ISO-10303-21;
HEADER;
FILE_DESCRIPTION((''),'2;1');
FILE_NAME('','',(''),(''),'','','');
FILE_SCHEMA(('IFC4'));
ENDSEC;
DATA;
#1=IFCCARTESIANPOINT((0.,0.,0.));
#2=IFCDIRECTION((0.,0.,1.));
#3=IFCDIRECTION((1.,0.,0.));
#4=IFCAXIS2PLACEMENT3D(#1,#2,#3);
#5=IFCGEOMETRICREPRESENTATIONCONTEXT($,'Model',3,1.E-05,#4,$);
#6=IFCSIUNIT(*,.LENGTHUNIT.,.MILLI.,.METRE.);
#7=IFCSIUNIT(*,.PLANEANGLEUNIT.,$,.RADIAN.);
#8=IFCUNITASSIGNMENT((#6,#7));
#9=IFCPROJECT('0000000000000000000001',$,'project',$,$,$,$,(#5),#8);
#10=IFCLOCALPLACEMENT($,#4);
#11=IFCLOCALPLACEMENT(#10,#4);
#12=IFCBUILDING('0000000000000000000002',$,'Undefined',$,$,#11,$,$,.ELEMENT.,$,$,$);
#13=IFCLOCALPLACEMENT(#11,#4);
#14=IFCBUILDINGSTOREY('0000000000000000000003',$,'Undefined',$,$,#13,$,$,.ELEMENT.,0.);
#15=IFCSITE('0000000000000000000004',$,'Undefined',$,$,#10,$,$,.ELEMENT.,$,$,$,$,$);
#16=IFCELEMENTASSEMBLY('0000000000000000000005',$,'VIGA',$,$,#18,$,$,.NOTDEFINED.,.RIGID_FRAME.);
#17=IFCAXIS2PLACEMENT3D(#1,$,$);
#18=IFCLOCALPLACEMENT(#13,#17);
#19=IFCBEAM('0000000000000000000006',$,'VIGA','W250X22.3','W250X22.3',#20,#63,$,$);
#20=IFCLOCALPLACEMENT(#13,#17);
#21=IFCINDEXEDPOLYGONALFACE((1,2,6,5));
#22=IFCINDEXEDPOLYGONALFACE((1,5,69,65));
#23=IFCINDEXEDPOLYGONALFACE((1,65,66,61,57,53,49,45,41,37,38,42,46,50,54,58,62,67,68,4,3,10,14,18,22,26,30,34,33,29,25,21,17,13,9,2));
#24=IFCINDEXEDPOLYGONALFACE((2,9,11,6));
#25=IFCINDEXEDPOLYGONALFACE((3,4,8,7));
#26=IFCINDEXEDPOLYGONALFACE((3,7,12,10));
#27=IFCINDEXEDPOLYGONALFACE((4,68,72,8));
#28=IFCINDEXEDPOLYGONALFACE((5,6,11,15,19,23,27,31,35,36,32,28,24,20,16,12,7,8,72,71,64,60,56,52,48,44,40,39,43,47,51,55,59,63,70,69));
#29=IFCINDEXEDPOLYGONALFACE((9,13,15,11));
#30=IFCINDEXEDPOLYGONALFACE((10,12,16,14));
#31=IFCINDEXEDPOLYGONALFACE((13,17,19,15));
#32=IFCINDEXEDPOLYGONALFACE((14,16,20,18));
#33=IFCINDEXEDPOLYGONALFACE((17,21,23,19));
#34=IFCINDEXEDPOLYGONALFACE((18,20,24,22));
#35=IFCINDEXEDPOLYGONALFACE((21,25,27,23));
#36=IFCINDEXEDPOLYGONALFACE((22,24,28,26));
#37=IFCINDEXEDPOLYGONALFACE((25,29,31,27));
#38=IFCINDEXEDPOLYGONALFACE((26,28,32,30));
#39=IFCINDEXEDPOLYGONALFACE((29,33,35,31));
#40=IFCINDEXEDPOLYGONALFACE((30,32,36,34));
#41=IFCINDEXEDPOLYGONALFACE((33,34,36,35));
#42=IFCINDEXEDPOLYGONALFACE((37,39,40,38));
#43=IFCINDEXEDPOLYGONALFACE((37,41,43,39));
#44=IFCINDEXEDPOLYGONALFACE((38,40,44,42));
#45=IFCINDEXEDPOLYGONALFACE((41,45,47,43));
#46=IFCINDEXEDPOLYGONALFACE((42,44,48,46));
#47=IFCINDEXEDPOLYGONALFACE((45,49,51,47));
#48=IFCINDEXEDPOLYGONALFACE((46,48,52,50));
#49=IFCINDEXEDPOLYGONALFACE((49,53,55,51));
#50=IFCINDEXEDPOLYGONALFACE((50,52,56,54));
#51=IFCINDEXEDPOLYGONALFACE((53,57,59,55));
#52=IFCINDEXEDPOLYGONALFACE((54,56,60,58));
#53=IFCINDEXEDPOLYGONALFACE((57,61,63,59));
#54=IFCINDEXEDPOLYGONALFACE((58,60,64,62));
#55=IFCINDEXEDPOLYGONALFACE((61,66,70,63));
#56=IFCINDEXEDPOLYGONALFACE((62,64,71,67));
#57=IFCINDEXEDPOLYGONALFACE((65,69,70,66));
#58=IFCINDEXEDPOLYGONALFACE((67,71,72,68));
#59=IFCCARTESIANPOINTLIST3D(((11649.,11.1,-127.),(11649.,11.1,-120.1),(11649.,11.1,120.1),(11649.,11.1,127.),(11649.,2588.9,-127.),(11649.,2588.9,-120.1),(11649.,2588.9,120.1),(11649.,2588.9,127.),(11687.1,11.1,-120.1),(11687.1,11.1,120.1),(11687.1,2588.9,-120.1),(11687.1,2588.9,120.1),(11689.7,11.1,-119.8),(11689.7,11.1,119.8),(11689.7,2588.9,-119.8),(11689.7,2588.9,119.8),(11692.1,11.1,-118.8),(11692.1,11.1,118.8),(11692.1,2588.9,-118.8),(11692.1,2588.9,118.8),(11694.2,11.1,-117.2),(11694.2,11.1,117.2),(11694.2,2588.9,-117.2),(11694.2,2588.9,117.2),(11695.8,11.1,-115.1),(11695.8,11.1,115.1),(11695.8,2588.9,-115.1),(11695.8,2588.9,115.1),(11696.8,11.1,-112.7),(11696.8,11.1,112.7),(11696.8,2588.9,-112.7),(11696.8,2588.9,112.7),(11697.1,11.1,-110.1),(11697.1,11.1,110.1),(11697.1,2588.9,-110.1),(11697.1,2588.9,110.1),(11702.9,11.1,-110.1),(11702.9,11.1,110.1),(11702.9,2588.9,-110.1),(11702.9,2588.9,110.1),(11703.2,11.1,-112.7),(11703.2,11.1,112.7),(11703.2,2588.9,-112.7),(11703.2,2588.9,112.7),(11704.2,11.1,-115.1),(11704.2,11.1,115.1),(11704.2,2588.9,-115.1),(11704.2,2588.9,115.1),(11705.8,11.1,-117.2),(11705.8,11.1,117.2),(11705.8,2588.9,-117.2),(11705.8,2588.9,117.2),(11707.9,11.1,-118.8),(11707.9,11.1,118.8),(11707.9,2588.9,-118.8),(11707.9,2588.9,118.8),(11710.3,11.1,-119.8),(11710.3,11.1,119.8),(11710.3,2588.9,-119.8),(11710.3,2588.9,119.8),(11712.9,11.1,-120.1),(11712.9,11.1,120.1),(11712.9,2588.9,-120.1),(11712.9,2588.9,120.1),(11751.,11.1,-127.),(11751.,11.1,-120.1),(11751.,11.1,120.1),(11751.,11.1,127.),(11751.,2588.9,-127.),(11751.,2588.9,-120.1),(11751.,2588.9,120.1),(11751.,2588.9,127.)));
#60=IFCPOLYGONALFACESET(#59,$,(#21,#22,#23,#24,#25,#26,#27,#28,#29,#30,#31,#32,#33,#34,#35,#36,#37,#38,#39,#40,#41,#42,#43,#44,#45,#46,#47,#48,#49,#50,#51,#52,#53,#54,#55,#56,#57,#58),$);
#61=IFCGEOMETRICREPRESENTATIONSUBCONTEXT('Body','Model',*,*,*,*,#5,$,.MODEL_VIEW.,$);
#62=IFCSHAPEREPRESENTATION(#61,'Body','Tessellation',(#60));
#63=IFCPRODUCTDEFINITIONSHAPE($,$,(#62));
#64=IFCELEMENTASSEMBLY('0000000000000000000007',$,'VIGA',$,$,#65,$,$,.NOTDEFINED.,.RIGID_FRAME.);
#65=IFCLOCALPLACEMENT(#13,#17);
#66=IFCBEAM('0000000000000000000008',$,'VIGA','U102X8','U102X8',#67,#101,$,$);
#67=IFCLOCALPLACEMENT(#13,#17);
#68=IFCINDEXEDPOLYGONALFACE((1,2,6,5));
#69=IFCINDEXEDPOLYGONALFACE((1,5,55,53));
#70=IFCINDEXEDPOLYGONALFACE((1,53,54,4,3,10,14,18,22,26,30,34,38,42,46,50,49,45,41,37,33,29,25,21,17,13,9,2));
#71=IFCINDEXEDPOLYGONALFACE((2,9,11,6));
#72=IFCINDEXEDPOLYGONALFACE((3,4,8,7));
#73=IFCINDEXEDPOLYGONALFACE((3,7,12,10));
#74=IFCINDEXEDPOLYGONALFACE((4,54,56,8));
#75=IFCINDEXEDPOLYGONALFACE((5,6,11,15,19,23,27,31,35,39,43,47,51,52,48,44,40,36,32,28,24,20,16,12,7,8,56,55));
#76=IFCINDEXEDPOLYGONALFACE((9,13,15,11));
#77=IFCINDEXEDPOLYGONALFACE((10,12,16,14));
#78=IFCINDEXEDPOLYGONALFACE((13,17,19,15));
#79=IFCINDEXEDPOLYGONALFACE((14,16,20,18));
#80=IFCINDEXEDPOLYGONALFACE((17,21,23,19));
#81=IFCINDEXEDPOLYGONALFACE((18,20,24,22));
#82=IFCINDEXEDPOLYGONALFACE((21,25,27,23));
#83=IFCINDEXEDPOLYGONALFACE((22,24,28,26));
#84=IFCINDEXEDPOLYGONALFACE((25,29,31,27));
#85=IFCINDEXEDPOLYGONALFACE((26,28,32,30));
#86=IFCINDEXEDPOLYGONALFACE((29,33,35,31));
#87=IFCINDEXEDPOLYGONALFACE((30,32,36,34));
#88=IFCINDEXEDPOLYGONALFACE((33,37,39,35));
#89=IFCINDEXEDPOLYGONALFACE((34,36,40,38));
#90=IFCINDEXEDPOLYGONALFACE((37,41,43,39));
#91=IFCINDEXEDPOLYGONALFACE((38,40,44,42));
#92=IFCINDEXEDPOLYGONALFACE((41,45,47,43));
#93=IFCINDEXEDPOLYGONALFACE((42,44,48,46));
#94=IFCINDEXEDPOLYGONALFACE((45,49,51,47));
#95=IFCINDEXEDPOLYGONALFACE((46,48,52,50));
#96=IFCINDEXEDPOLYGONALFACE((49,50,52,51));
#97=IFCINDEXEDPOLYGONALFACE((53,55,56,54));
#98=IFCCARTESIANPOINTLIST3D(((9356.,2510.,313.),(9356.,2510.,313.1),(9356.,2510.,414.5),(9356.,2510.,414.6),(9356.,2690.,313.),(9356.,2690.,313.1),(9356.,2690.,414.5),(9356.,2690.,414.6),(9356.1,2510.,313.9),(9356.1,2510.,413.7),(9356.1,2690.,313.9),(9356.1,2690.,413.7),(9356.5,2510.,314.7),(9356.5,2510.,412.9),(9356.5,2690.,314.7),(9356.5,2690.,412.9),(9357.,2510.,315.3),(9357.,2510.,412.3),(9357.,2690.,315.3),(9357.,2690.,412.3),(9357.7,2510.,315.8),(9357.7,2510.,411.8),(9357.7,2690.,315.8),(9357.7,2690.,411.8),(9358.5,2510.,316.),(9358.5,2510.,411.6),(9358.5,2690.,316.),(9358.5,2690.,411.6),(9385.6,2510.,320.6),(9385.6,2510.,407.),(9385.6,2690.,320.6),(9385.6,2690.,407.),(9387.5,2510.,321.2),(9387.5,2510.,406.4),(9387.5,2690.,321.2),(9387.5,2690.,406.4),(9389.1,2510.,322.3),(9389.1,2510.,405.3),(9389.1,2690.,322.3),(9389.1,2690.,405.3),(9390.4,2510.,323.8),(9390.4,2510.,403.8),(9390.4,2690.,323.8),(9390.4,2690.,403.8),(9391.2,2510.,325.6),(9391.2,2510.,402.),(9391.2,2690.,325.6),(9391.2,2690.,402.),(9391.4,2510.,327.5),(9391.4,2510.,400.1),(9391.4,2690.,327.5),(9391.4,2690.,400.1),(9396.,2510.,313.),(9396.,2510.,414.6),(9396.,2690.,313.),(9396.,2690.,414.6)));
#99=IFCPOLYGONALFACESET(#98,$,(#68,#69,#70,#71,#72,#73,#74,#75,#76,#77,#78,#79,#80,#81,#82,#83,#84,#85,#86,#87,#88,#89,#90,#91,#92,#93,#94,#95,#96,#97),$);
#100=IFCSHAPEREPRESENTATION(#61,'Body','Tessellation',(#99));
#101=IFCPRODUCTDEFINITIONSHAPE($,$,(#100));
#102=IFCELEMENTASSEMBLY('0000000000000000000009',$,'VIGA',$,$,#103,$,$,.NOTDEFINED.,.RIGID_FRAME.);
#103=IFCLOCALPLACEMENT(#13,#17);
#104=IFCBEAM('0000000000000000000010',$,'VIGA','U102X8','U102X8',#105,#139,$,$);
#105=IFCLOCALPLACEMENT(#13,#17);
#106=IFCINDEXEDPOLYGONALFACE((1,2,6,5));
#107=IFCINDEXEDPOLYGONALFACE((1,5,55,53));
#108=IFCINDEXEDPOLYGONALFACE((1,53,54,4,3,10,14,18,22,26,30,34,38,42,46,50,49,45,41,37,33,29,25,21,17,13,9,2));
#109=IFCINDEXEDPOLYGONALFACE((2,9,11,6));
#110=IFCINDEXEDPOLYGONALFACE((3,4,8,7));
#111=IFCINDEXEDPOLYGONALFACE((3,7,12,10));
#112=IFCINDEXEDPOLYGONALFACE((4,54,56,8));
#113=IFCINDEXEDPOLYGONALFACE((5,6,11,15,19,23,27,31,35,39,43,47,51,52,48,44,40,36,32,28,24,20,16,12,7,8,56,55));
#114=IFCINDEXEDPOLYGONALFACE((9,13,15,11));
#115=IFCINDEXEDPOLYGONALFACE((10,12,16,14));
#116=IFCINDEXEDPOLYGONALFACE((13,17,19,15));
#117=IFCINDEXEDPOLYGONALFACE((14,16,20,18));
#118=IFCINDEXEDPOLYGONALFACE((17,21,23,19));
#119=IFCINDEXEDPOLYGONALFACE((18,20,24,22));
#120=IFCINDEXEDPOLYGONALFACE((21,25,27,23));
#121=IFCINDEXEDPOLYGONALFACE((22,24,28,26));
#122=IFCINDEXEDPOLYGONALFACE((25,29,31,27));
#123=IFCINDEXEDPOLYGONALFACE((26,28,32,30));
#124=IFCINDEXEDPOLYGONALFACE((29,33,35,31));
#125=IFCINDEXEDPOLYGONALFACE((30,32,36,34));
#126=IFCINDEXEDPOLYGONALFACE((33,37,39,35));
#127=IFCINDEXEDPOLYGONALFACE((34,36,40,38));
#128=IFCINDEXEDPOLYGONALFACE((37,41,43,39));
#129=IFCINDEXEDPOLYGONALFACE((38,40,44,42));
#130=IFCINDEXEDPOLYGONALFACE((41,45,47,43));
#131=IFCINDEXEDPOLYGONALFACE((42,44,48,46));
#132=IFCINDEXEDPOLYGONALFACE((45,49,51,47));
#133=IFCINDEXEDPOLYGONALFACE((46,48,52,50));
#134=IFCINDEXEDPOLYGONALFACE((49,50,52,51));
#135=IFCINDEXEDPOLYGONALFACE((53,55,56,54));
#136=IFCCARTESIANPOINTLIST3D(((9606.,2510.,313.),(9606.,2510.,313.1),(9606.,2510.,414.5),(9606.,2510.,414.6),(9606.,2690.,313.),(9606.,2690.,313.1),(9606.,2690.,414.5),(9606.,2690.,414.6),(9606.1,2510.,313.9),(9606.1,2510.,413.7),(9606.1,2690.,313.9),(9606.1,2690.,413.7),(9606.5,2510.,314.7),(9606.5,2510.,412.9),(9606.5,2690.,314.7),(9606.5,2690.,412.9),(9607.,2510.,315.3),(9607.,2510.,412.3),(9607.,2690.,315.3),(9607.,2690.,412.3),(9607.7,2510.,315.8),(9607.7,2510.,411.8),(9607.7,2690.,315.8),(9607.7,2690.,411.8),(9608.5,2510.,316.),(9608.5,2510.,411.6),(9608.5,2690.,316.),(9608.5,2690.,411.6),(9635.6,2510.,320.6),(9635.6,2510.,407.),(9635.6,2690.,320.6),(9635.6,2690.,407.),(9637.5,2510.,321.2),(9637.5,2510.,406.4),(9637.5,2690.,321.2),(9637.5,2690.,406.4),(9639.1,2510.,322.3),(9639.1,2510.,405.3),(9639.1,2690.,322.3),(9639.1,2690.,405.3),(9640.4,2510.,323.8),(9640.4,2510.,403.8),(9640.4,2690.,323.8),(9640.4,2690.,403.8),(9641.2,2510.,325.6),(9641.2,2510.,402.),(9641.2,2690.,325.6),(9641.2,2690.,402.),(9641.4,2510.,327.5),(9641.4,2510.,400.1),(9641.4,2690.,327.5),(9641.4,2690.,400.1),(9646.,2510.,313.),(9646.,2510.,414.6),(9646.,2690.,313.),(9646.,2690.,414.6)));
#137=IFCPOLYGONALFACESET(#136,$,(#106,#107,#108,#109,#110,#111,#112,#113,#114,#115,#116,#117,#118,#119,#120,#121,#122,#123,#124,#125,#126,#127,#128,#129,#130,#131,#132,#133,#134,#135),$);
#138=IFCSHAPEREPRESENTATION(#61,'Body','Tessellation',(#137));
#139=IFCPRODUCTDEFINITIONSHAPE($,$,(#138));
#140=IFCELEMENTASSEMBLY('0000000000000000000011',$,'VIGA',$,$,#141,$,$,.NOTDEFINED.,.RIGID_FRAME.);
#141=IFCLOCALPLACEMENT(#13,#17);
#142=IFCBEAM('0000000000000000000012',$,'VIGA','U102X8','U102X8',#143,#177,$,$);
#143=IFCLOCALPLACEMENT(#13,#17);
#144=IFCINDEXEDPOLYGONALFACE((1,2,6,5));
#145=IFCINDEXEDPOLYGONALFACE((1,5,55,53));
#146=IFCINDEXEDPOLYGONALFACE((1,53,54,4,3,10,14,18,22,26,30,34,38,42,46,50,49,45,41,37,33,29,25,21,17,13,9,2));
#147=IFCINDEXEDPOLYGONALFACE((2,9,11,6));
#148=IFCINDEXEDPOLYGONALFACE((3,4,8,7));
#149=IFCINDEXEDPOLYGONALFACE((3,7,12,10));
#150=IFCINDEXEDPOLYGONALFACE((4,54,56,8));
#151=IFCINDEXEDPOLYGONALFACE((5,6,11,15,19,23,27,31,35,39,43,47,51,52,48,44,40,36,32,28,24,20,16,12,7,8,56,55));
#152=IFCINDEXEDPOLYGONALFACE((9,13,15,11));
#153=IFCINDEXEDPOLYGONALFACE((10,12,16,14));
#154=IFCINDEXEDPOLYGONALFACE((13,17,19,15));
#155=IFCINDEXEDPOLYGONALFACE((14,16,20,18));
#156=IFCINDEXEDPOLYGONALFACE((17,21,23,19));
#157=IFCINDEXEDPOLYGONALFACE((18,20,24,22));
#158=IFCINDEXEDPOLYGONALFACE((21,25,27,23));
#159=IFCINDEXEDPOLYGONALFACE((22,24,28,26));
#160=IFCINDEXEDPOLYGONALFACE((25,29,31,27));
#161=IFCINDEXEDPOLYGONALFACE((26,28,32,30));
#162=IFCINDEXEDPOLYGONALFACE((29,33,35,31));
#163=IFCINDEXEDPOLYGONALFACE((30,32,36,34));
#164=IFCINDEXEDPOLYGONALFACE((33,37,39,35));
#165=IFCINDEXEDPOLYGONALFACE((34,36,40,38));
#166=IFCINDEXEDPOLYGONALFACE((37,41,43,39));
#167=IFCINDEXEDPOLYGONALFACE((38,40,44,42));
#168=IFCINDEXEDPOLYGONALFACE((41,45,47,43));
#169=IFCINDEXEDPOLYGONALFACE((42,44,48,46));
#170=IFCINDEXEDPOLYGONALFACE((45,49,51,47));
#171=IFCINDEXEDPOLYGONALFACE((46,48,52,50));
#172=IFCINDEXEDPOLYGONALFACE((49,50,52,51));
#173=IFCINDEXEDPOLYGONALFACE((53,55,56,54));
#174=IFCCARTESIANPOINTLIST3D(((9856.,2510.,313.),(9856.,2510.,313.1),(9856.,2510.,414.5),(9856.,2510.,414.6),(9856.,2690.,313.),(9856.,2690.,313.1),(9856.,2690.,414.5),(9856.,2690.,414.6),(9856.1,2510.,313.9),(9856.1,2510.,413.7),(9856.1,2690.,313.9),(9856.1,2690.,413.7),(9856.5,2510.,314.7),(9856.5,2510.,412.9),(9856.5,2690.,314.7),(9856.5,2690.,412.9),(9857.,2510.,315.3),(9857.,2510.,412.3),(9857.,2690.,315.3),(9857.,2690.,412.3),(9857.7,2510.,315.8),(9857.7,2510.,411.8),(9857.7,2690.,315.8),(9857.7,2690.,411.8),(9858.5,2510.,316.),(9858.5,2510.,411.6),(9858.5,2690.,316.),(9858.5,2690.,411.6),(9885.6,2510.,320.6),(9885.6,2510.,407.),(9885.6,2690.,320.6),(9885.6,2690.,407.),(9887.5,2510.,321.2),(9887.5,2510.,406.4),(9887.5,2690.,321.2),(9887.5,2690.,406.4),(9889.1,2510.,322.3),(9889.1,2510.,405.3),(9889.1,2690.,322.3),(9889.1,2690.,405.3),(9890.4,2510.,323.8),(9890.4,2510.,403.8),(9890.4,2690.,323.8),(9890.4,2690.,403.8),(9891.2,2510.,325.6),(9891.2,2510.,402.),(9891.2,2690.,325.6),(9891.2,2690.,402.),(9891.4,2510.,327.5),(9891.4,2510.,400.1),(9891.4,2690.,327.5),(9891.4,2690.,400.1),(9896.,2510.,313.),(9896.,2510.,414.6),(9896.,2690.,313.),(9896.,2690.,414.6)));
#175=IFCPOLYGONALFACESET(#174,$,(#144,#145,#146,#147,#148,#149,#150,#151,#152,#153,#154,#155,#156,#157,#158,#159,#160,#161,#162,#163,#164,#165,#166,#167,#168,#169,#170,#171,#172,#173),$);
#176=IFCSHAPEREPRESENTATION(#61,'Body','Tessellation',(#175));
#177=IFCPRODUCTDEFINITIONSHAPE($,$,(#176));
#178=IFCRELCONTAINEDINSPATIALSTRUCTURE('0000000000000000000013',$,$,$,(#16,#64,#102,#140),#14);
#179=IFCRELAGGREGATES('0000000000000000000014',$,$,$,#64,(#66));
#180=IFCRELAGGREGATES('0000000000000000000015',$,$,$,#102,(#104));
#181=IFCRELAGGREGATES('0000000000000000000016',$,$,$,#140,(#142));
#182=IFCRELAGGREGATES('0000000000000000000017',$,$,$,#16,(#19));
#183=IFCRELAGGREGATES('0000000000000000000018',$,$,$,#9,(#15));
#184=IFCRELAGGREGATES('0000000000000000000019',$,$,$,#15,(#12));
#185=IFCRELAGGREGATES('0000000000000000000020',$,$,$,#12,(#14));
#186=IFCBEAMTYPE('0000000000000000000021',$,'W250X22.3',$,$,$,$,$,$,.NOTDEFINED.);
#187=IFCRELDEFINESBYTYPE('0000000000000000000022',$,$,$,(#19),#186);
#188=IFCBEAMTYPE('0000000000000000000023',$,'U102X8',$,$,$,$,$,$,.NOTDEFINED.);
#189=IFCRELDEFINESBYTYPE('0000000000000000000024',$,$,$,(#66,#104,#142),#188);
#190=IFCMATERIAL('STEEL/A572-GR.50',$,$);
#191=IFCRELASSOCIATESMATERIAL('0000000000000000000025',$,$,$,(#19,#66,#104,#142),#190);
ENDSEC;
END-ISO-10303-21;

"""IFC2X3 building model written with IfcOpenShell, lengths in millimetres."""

from ifc_helpers import new_model, si_unit, frame, origin_with_axes, origin_2d_with_axis, place, context, subcontext, project, spatial, i_section, u_section, extrude, material, type_object, element, aggregate, save


model = new_model("IFC2X3")

# Units and contexts
model_context = context("Model", 3, precision=1e-05, world=origin_with_axes())
body_context = subcontext(model_context, "Body", "Model", "MODEL_VIEW")
ifc_project = project(units=[si_unit("LENGTHUNIT", "METRE", prefix="MILLI"), si_unit("PLANEANGLEUNIT", "RADIAN")], contexts=[model_context])

# Site, building, storey
site_placement = place(None, origin_with_axes())
site = spatial("IfcSite", under=ifc_project, at=site_placement, Name="Undefined", CompositionType="ELEMENT")
building_placement = place(site_placement, origin_with_axes())
building = spatial("IfcBuilding", under=site, at=building_placement, Name="Undefined", CompositionType="ELEMENT")
storey_placement = place(building_placement, origin_with_axes())
storey = spatial("IfcBuildingStorey", under=building, at=storey_placement, Name="Undefined", CompositionType="ELEMENT", Elevation=0.0)

# Element assemblies, beams
assembly_1_placement = place(storey_placement, origin_with_axes())
assembly_1 = element("IfcElementAssembly", 1, at=assembly_1_placement, inside=storey, Name="VIGA", AssemblyPlace="NOTDEFINED", PredefinedType="RIGID_FRAME")
ifc_material_1 = material(Name="STEEL/A572-GR.50")
beam_type_1 = type_object("IfcBeamType", Name="W250X22.3", PredefinedType="NOTDEFINED")
beam_1_placement = place(assembly_1_placement, frame((11700.0, 11.1, 0.0), z_axis=(0.0, 0.0, 1.0), x_axis=(0.0, 1.0, 0.0)))
beam_1 = element("IfcBeam", 2, at=beam_1_placement, type_object=beam_type_1, material=ifc_material_1, Name="VIGA", Description="W250X22.3", ObjectType="W250X22.3", context=body_context, shape_type="SweptSolid", body=[
    extrude(i_section(OverallWidth=102.0, OverallDepth=254.0, WebThickness=5.8, FlangeThickness=6.9, FilletRadius=10.0, at=origin_2d_with_axis()), frame((2577.8, 0.0, 0.0), z_axis=(-1.0, 0.0, 0.0), x_axis=(0.0, -1.0, 0.0)), (0.0, 0.0, 1.0), 2577.8),
])
assembly_2_placement = place(storey_placement, origin_with_axes())
assembly_2 = element("IfcElementAssembly", 3, at=assembly_2_placement, inside=storey, Name="VIGA", AssemblyPlace="NOTDEFINED", PredefinedType="RIGID_FRAME")
beam_type_2 = type_object("IfcBeamType", Name="U102X8", PredefinedType="NOTDEFINED")
beam_2_placement = place(assembly_2_placement, frame((9376.0, 2690.0, 363.8), z_axis=(0.0, 0.0, 1.0), x_axis=(0.0, -1.0, 0.0)))
beam_2 = element("IfcBeam", 4, at=beam_2_placement, type_object=beam_type_2, material=ifc_material_1, Name="VIGA", Description="U102X8", ObjectType="U102X8", context=body_context, shape_type="SweptSolid", body=[
    extrude(u_section(Depth=101.6, FlangeWidth=40.0, WebThickness=4.6, FlangeThickness=6.0, FilletRadius=7.0, EdgeRadius=3.0, FlangeSlope=0.16839, at=origin_2d_with_axis()), frame((180.0, 0.0, 0.0), z_axis=(-1.0, 0.0, 0.0), x_axis=(0.0, -1.0, 0.0)), (0.0, 0.0, 1.0), 180.0),
])
aggregate(assembly_2, [beam_2])
assembly_3_placement = place(storey_placement, origin_with_axes())
assembly_3 = element("IfcElementAssembly", 5, at=assembly_3_placement, inside=storey, Name="VIGA", AssemblyPlace="NOTDEFINED", PredefinedType="RIGID_FRAME")
beam_3_placement = place(assembly_3_placement, frame((9626.0, 2690.0, 363.8), z_axis=(0.0, 0.0, 1.0), x_axis=(0.0, -1.0, 0.0)))
beam_3 = element("IfcBeam", 6, at=beam_3_placement, type_object=beam_type_2, material=ifc_material_1, Name="VIGA", Description="U102X8", ObjectType="U102X8", context=body_context, shape_type="SweptSolid", body=[
    extrude(u_section(Depth=101.6, FlangeWidth=40.0, WebThickness=4.6, FlangeThickness=6.0, FilletRadius=7.0, EdgeRadius=3.0, FlangeSlope=0.16839, at=origin_2d_with_axis()), frame((180.0, 0.0, 0.0), z_axis=(-1.0, 0.0, 0.0), x_axis=(0.0, -1.0, 0.0)), (0.0, 0.0, 1.0), 180.0),
])
aggregate(assembly_3, [beam_3])
assembly_4_placement = place(storey_placement, origin_with_axes())
assembly_4 = element("IfcElementAssembly", 7, at=assembly_4_placement, inside=storey, Name="VIGA", AssemblyPlace="NOTDEFINED", PredefinedType="RIGID_FRAME")
beam_4_placement = place(assembly_4_placement, frame((9876.0, 2690.0, 363.8), z_axis=(0.0, 0.0, 1.0), x_axis=(0.0, -1.0, 0.0)))
beam_4 = element("IfcBeam", 8, at=beam_4_placement, type_object=beam_type_2, material=ifc_material_1, Name="VIGA", Description="U102X8", ObjectType="U102X8", context=body_context, shape_type="SweptSolid", body=[
    extrude(u_section(Depth=101.6, FlangeWidth=40.0, WebThickness=4.6, FlangeThickness=6.0, FilletRadius=7.0, EdgeRadius=3.0, FlangeSlope=0.16839, at=origin_2d_with_axis()), frame((180.0, 0.0, 0.0), z_axis=(-1.0, 0.0, 0.0), x_axis=(0.0, -1.0, 0.0)), (0.0, 0.0, 1.0), 180.0),
])
aggregate(assembly_4, [beam_4])

aggregate(assembly_1, [beam_1])

save(model, "model.ifc")
